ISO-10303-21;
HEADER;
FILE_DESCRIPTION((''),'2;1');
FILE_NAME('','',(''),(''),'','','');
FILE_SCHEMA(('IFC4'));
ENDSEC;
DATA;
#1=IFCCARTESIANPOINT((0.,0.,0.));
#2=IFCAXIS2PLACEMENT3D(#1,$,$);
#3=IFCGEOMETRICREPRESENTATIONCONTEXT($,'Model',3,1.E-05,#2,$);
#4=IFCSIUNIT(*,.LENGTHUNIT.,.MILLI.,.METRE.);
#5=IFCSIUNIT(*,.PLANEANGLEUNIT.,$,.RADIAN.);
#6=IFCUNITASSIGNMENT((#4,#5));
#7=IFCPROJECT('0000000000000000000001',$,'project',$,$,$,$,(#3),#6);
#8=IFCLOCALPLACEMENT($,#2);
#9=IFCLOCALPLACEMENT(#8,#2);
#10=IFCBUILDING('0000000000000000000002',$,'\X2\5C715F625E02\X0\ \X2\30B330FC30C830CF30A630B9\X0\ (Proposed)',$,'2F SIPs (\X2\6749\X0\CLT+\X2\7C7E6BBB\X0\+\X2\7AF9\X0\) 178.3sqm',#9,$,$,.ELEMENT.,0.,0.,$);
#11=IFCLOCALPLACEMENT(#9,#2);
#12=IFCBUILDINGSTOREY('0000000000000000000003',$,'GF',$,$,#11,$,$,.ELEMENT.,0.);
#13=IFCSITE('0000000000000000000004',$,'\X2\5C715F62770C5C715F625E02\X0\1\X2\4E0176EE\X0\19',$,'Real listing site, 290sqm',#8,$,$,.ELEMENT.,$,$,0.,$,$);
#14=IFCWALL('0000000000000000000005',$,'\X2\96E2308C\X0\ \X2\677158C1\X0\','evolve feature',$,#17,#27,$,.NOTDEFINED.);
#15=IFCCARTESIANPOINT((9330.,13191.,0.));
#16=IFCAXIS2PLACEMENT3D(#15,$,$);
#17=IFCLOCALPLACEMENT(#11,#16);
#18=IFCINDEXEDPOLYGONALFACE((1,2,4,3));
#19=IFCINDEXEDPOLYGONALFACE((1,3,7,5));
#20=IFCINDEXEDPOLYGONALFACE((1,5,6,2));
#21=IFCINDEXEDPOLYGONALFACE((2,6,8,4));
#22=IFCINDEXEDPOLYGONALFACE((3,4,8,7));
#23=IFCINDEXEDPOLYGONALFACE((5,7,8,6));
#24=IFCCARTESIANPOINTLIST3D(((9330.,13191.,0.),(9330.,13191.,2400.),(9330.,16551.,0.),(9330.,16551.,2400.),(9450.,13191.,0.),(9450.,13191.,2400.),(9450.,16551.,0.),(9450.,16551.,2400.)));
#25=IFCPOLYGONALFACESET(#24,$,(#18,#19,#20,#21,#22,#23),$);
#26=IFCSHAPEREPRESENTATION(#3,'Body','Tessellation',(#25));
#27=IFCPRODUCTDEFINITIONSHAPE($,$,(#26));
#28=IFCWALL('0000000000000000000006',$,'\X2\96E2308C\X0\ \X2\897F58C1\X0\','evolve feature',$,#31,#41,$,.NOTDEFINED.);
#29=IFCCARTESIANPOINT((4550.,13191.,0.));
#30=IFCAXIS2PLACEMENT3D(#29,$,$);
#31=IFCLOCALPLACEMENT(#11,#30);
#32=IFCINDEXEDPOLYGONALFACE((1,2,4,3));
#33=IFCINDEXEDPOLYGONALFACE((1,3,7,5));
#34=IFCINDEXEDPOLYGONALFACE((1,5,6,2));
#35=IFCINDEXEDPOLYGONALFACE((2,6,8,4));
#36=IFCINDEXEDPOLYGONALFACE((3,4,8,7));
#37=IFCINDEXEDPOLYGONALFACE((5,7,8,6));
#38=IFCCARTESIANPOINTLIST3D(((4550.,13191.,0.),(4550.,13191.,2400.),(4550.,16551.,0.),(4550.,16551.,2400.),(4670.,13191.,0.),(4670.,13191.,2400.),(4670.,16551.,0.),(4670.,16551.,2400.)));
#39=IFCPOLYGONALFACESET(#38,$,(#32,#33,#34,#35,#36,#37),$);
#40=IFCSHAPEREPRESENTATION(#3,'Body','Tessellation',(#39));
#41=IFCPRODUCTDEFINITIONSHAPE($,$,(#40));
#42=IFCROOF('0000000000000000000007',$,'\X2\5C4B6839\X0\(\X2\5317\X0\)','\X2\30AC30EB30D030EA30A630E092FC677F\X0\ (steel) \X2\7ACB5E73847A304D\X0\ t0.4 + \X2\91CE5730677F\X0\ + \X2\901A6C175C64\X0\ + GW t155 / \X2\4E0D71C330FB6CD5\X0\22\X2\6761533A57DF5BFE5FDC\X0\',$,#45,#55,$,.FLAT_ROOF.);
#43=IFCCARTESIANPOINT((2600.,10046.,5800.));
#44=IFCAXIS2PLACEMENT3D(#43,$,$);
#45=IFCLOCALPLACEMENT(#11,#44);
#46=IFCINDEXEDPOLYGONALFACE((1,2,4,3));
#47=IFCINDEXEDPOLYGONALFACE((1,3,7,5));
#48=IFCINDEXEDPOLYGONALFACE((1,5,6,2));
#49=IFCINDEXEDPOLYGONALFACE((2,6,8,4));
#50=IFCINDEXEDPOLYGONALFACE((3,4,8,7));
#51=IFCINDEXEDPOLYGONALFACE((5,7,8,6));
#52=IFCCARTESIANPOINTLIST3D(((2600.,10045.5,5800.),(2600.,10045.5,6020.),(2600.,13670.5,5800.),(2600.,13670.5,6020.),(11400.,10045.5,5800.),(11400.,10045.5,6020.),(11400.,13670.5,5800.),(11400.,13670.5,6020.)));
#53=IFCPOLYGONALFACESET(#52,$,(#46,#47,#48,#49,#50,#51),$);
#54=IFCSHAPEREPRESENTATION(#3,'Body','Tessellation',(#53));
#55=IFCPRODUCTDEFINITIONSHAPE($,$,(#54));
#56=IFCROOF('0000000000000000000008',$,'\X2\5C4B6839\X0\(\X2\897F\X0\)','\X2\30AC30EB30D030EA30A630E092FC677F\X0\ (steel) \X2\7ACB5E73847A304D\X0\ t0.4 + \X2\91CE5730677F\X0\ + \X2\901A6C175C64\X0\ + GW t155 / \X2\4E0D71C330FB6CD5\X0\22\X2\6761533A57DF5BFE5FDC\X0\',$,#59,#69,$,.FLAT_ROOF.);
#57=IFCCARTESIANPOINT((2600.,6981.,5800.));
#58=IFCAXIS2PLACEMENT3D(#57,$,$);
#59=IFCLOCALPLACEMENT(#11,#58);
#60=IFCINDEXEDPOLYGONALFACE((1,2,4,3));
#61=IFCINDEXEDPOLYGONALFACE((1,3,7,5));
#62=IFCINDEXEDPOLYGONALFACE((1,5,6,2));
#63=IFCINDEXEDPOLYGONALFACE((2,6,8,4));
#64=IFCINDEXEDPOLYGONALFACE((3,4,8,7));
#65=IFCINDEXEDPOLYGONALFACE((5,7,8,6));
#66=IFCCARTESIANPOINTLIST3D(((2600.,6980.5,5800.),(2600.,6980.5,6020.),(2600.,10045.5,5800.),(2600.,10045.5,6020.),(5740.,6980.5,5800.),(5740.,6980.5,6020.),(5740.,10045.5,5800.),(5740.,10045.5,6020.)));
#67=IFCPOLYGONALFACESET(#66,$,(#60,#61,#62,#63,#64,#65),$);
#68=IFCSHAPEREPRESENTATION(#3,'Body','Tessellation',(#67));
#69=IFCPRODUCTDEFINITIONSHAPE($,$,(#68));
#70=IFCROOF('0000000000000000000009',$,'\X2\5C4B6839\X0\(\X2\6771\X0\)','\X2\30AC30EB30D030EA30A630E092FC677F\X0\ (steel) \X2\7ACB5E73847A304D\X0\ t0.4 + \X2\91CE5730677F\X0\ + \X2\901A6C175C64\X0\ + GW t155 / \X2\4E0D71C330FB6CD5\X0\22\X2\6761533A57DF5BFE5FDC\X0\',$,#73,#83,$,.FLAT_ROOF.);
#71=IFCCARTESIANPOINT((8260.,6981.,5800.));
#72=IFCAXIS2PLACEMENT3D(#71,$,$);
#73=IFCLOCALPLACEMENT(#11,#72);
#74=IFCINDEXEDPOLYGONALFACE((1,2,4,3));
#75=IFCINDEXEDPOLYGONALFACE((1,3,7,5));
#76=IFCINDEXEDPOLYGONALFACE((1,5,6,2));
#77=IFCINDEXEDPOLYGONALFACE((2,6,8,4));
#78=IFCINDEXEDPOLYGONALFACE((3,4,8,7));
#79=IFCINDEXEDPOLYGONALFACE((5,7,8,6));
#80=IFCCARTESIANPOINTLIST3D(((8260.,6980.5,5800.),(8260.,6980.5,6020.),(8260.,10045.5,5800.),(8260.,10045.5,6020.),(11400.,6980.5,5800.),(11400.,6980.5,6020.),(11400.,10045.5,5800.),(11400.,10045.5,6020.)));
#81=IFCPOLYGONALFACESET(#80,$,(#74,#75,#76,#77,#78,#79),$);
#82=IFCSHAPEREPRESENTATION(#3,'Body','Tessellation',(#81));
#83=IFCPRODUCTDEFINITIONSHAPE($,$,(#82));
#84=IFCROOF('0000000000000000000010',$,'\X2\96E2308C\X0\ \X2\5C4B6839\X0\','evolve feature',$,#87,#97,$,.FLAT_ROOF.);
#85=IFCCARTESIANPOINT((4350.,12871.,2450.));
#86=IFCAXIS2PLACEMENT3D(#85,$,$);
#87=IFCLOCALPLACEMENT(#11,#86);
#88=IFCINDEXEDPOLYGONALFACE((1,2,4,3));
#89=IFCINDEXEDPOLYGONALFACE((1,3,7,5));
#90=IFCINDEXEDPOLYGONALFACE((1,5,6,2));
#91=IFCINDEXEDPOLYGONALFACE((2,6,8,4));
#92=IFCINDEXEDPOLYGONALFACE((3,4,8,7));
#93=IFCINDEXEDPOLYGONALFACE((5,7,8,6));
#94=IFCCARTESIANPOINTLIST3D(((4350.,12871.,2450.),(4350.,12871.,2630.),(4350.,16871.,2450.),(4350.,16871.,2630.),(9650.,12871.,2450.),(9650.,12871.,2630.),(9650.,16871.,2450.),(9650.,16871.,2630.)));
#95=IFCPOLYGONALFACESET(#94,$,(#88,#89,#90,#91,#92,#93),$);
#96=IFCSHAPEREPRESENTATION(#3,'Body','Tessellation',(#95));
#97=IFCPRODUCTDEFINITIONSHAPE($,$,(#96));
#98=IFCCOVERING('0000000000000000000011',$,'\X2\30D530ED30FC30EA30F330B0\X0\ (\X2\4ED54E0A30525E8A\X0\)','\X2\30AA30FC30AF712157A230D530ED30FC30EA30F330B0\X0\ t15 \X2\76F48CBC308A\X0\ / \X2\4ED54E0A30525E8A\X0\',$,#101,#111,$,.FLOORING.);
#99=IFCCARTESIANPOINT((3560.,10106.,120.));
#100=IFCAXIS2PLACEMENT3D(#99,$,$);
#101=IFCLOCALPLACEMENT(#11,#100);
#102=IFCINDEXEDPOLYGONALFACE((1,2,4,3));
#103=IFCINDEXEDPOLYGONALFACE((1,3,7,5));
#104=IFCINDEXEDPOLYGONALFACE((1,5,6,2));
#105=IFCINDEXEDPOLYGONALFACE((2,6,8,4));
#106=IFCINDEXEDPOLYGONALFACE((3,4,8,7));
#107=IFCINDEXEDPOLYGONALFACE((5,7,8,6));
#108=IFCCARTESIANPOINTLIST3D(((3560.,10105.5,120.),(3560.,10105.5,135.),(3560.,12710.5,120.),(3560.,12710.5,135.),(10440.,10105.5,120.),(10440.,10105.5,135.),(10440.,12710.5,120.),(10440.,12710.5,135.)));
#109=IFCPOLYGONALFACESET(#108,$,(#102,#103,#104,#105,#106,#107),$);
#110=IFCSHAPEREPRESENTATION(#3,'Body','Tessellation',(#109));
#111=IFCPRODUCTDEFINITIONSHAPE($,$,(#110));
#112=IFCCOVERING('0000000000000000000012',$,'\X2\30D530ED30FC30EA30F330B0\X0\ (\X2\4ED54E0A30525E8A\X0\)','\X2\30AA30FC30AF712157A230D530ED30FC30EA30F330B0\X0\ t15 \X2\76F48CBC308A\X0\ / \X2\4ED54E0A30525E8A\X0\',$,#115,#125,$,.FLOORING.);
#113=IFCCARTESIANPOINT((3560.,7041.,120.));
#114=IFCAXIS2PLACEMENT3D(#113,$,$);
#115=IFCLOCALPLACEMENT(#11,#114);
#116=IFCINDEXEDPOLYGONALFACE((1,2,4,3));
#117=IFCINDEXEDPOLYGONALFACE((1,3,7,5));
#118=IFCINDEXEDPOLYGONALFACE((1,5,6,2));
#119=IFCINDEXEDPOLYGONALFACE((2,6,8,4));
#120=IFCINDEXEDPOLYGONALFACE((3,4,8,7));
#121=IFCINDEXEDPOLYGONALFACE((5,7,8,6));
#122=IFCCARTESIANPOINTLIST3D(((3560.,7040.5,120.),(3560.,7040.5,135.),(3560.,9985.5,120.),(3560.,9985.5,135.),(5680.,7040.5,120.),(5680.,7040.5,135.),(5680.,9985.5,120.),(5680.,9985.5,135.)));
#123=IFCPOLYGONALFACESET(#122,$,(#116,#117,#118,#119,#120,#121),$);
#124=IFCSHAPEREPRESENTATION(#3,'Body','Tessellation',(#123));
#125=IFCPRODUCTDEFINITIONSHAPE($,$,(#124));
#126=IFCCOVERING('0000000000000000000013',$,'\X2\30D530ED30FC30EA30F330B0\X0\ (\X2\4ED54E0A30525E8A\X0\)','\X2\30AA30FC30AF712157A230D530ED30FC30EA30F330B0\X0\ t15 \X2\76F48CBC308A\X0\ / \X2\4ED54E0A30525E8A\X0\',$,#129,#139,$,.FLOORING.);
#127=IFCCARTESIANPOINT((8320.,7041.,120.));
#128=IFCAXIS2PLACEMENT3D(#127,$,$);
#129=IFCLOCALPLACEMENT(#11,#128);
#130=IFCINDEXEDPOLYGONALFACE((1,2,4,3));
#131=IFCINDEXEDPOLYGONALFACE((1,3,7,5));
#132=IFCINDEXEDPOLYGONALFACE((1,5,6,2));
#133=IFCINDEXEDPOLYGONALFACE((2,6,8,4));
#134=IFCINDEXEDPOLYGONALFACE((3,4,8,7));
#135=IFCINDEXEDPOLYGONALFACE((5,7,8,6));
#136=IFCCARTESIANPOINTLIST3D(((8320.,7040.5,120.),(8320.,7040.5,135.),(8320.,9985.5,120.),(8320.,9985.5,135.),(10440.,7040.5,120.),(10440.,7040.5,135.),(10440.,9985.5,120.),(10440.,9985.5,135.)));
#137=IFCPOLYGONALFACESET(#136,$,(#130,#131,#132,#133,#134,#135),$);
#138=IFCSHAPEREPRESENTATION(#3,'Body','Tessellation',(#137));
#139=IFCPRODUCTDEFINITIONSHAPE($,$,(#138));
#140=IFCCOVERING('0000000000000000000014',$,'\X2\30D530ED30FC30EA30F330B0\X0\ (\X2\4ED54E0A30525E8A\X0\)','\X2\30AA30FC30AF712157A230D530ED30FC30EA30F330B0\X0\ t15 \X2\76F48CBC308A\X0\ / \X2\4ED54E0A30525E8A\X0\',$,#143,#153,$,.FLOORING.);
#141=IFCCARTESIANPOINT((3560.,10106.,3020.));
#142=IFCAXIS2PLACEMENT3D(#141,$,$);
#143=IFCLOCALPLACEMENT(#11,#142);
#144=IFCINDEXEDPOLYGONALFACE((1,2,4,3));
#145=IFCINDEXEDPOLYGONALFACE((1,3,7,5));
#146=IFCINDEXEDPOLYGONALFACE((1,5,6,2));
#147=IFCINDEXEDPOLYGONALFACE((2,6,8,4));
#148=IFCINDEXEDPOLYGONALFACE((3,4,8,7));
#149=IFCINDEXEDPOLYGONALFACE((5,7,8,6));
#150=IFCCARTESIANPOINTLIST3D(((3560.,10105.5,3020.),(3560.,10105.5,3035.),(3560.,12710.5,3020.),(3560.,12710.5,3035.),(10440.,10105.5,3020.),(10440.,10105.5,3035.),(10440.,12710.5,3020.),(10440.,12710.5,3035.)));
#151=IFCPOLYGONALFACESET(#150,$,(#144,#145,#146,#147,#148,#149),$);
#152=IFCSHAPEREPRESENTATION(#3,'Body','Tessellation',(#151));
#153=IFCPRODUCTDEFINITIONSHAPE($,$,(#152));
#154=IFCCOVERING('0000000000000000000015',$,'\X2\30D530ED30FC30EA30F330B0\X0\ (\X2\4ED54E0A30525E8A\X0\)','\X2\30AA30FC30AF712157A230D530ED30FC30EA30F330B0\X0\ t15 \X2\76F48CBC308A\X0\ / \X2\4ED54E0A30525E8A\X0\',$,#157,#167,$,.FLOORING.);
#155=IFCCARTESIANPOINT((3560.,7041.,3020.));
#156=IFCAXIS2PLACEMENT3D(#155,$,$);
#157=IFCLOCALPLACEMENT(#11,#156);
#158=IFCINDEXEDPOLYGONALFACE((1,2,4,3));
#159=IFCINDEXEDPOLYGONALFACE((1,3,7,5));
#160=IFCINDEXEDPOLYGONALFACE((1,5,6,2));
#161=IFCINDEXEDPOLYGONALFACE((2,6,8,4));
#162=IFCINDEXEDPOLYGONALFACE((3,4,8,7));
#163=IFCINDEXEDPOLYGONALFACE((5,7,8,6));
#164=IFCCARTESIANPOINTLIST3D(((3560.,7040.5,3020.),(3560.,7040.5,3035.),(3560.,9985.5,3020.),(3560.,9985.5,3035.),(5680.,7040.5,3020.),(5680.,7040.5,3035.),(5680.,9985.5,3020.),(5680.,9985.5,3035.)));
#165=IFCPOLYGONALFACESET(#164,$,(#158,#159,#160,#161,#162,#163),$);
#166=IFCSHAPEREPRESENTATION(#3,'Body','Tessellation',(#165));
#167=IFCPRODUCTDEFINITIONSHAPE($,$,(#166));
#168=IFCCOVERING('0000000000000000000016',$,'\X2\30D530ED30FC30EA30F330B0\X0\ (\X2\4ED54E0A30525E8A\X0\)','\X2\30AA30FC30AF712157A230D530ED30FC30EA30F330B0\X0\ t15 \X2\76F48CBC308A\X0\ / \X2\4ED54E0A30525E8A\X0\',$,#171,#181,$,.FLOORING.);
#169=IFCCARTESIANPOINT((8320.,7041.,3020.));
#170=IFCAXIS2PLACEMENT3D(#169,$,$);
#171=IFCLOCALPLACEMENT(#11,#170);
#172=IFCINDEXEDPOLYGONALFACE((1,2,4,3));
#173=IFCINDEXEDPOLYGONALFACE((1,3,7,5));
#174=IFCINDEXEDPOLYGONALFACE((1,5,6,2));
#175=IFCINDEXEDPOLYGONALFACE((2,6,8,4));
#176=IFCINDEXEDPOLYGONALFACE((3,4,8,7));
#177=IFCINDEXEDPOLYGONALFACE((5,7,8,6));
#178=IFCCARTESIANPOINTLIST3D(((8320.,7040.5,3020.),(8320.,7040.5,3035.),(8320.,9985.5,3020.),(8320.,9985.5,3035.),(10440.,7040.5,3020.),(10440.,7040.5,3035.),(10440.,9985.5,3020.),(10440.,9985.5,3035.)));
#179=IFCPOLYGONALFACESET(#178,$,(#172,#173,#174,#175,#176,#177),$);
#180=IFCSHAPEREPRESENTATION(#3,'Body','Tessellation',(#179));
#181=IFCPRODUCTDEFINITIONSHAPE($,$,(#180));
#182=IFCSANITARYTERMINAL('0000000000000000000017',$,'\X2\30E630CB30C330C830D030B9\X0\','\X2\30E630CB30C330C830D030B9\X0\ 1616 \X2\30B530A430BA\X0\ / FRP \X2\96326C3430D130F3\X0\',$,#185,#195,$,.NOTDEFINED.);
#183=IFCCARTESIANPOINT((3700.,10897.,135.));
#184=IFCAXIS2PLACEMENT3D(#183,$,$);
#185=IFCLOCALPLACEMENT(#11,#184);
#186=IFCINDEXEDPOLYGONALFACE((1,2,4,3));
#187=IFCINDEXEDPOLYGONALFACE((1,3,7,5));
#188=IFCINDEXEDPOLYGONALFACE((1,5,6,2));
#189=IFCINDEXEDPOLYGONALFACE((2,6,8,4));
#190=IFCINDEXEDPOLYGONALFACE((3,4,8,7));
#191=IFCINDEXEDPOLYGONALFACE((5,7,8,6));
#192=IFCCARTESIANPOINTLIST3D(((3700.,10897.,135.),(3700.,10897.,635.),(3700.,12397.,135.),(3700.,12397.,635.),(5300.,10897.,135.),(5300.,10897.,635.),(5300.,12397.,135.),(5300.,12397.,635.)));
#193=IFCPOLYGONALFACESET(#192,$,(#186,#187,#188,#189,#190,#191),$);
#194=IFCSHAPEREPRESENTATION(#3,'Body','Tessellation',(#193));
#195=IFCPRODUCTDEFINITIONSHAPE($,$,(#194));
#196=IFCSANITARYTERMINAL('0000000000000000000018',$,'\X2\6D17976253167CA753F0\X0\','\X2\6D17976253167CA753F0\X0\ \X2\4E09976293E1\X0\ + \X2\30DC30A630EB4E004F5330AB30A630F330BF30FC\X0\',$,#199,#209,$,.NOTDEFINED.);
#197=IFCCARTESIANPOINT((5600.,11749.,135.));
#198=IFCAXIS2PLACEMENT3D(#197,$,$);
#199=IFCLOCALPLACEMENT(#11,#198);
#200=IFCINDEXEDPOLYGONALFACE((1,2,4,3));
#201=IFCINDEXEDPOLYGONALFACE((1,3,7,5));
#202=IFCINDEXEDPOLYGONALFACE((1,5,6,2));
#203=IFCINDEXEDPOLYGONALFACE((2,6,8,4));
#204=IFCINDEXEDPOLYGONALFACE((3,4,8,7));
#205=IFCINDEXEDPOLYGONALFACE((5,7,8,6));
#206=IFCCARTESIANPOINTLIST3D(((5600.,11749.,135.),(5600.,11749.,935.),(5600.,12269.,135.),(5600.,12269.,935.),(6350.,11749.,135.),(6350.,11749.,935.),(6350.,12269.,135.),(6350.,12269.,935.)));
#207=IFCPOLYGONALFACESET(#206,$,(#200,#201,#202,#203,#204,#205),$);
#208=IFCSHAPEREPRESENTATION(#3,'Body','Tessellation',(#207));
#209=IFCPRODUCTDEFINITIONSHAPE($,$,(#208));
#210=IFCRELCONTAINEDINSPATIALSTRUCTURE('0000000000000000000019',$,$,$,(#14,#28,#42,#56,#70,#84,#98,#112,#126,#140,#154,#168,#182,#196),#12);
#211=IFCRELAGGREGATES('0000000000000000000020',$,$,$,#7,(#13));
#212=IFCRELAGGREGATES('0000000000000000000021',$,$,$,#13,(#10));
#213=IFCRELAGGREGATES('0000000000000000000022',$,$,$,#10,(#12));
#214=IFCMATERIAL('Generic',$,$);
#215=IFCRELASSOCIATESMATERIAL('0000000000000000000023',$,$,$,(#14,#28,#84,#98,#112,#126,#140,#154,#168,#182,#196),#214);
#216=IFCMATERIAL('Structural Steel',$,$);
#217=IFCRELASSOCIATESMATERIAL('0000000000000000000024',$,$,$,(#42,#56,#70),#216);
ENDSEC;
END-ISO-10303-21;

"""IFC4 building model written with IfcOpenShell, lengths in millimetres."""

from ifc_helpers import new_model, si_unit, frame, frame_2d, origin, place, context, project, spatial, rectangle, extrude, material, element, save


model = new_model("IFC4")

# Units and contexts
model_context = context("Model", 3, precision=1e-05, world=origin())
ifc_project = project(units=[si_unit("LENGTHUNIT", "METRE", prefix="MILLI"), si_unit("PLANEANGLEUNIT", "RADIAN")], contexts=[model_context])

# Site, building, storey
site_placement = place(None, origin())
site = spatial("IfcSite", under=ifc_project, at=site_placement, Name="山形県山形市1丁目19", ObjectType="Real listing site, 290sqm", CompositionType="ELEMENT", RefElevation=0.0)
building_placement = place(site_placement, origin())
building = spatial("IfcBuilding", under=site, at=building_placement, Name="山形市 コートハウス (Proposed)", ObjectType="2F SIPs (杉CLT+籾殻+竹) 178.3sqm", CompositionType="ELEMENT", ElevationOfRefHeight=0.0, ElevationOfTerrain=0.0)
storey_placement = place(building_placement, origin())
storey = spatial("IfcBuildingStorey", under=building, at=storey_placement, Name="GF", CompositionType="ELEMENT", Elevation=0.0)

# Shared definitions
ifc_material_1 = material(Name="Generic")

# Walls
wall_1_placement = place(storey_placement, frame((9330.0, 13191.0, 0.0)))
element("IfcWall", 1, at=wall_1_placement, inside=storey, material=ifc_material_1, Name="離れ 東壁", Description="evolve feature", PredefinedType="NOTDEFINED", context=model_context, shape_type="SweptSolid", body=[
    extrude(rectangle(XDim=120.0, YDim=3360.0, at=frame_2d((60.0, 1680.0))), frame((9330.0, 13191.0, 0.0)), (0.0, 0.0, 1.0), 2400.0),
])
wall_2_placement = place(storey_placement, frame((4550.0, 13191.0, 0.0)))
element("IfcWall", 2, at=wall_2_placement, inside=storey, material=ifc_material_1, Name="離れ 西壁", Description="evolve feature", PredefinedType="NOTDEFINED", context=model_context, shape_type="SweptSolid", body=[
    extrude(rectangle(XDim=120.0, YDim=3360.0, at=frame_2d((60.0, 1680.0))), frame((4550.0, 13191.0, 0.0)), (0.0, 0.0, 1.0), 2400.0),
])

# Roofs
ifc_material_2 = material(Name="Structural Steel")
for number, where, name in (
    (3, (2600.0, 10046.0, 5800.0), "屋根(北)"),
):
    element("IfcRoof", number, at=place(storey_placement, frame(where)), inside=storey, material=ifc_material_2, Name=name, Description="ガルバリウム鋼板 (steel) 立平葺き t0.4 + 野地板 + 通気層 + GW t155 / 不燃・法22条区域対応", PredefinedType="FLAT_ROOF", context=model_context, shape_type="SweptSolid", body=[
        extrude(rectangle(XDim=8800.0, YDim=3625.0, at=frame_2d((4400.0, 1812.0))), frame((2600.0, 10046.0, 5800.0)), (0.0, 0.0, 1.0), 220.0),
    ])
roof_1_placement = place(storey_placement, frame((2600.0, 6981.0, 5800.0)))
element("IfcRoof", 4, at=roof_1_placement, inside=storey, material=ifc_material_2, Name="屋根(西)", Description="ガルバリウム鋼板 (steel) 立平葺き t0.4 + 野地板 + 通気層 + GW t155 / 不燃・法22条区域対応", PredefinedType="FLAT_ROOF", context=model_context, shape_type="SweptSolid", body=[
    extrude(rectangle(XDim=3140.0, YDim=3065.0, at=frame_2d((1570.0, 1532.0))), frame((2600.0, 6981.0, 5800.0)), (0.0, 0.0, 1.0), 220.0),
])
roof_2_placement = place(storey_placement, frame((8260.0, 6981.0, 5800.0)))
element("IfcRoof", 5, at=roof_2_placement, inside=storey, material=ifc_material_2, Name="屋根(東)", Description="ガルバリウム鋼板 (steel) 立平葺き t0.4 + 野地板 + 通気層 + GW t155 / 不燃・法22条区域対応", PredefinedType="FLAT_ROOF", context=model_context, shape_type="SweptSolid", body=[
    extrude(rectangle(XDim=3140.0, YDim=3065.0, at=frame_2d((1570.0, 1532.0))), frame((8260.0, 6981.0, 5800.0)), (0.0, 0.0, 1.0), 220.0),
])
roof_3_placement = place(storey_placement, frame((4350.0, 12871.0, 2450.0)))
element("IfcRoof", 6, at=roof_3_placement, inside=storey, material=ifc_material_1, Name="離れ 屋根", Description="evolve feature", PredefinedType="FLAT_ROOF", context=model_context, shape_type="SweptSolid", body=[
    extrude(rectangle(XDim=5300.0, YDim=4000.0, at=frame_2d((2650.0, 2000.0))), frame((4350.0, 12871.0, 2450.0)), (0.0, 0.0, 1.0), 180.0),
])

# Coverings
covering_1_placement = place(storey_placement, frame((3560.0, 10106.0, 120.0)))
element("IfcCovering", 7, at=covering_1_placement, inside=storey, material=ifc_material_1, Name="フローリング (仕上げ床)", Description="オーク無垢フローリング t15 直貼り / 仕上げ床", PredefinedType="FLOORING", context=model_context, shape_type="SweptSolid", body=[
    extrude(rectangle(XDim=6880.0, YDim=2605.0, at=frame_2d((3440.0, 1302.0))), frame((3560.0, 10106.0, 120.0)), (0.0, 0.0, 1.0), 15.0),
])
covering_2_placement = place(storey_placement, frame((3560.0, 7041.0, 120.0)))
element("IfcCovering", 8, at=covering_2_placement, inside=storey, material=ifc_material_1, Name="フローリング (仕上げ床)", Description="オーク無垢フローリング t15 直貼り / 仕上げ床", PredefinedType="FLOORING", context=model_context, shape_type="SweptSolid", body=[
    extrude(rectangle(XDim=2120.0, YDim=2945.0, at=frame_2d((1060.0, 1472.0))), frame((3560.0, 7041.0, 120.0)), (0.0, 0.0, 1.0), 15.0),
])
covering_3_placement = place(storey_placement, frame((8320.0, 7041.0, 120.0)))
element("IfcCovering", 9, at=covering_3_placement, inside=storey, material=ifc_material_1, Name="フローリング (仕上げ床)", Description="オーク無垢フローリング t15 直貼り / 仕上げ床", PredefinedType="FLOORING", context=model_context, shape_type="SweptSolid", body=[
    extrude(rectangle(XDim=2120.0, YDim=2945.0, at=frame_2d((1060.0, 1472.0))), frame((8320.0, 7041.0, 120.0)), (0.0, 0.0, 1.0), 15.0),
])
covering_4_placement = place(storey_placement, frame((3560.0, 10106.0, 3020.0)))
element("IfcCovering", 10, at=covering_4_placement, inside=storey, material=ifc_material_1, Name="フローリング (仕上げ床)", Description="オーク無垢フローリング t15 直貼り / 仕上げ床", PredefinedType="FLOORING", context=model_context, shape_type="SweptSolid", body=[
    extrude(rectangle(XDim=6880.0, YDim=2605.0, at=frame_2d((3440.0, 1302.0))), frame((3560.0, 10106.0, 3020.0)), (0.0, 0.0, 1.0), 15.0),
])
covering_5_placement = place(storey_placement, frame((3560.0, 7041.0, 3020.0)))
element("IfcCovering", 11, at=covering_5_placement, inside=storey, material=ifc_material_1, Name="フローリング (仕上げ床)", Description="オーク無垢フローリング t15 直貼り / 仕上げ床", PredefinedType="FLOORING", context=model_context, shape_type="SweptSolid", body=[
    extrude(rectangle(XDim=2120.0, YDim=2945.0, at=frame_2d((1060.0, 1472.0))), frame((3560.0, 7041.0, 3020.0)), (0.0, 0.0, 1.0), 15.0),
])
covering_6_placement = place(storey_placement, frame((8320.0, 7041.0, 3020.0)))
element("IfcCovering", 12, at=covering_6_placement, inside=storey, material=ifc_material_1, Name="フローリング (仕上げ床)", Description="オーク無垢フローリング t15 直貼り / 仕上げ床", PredefinedType="FLOORING", context=model_context, shape_type="SweptSolid", body=[
    extrude(rectangle(XDim=2120.0, YDim=2945.0, at=frame_2d((1060.0, 1472.0))), frame((8320.0, 7041.0, 3020.0)), (0.0, 0.0, 1.0), 15.0),
])

# Sanitary terminals
sanitary_terminal_1_placement = place(storey_placement, frame((3700.0, 10897.0, 135.0)))
element("IfcSanitaryTerminal", 13, at=sanitary_terminal_1_placement, inside=storey, material=ifc_material_1, Name="ユニットバス", Description="ユニットバス 1616 サイズ / FRP 防水パン", PredefinedType="NOTDEFINED", context=model_context, shape_type="SweptSolid", body=[
    extrude(rectangle(XDim=1600.0, YDim=1500.0, at=frame_2d((800.0, 750.0))), frame((3700.0, 10897.0, 135.0)), (0.0, 0.0, 1.0), 500.0),
])
sanitary_terminal_2_placement = place(storey_placement, frame((5600.0, 11749.0, 135.0)))
element("IfcSanitaryTerminal", 14, at=sanitary_terminal_2_placement, inside=storey, material=ifc_material_1, Name="洗面化粧台", Description="洗面化粧台 三面鏡 + ボウル一体カウンター", PredefinedType="NOTDEFINED", context=model_context, shape_type="SweptSolid", body=[
    extrude(rectangle(XDim=750.0, YDim=520.0, at=frame_2d((375.0, 260.0))), frame((5600.0, 11749.0, 135.0)), (0.0, 0.0, 1.0), 800.0),
])

save(model, "model.ifc")
